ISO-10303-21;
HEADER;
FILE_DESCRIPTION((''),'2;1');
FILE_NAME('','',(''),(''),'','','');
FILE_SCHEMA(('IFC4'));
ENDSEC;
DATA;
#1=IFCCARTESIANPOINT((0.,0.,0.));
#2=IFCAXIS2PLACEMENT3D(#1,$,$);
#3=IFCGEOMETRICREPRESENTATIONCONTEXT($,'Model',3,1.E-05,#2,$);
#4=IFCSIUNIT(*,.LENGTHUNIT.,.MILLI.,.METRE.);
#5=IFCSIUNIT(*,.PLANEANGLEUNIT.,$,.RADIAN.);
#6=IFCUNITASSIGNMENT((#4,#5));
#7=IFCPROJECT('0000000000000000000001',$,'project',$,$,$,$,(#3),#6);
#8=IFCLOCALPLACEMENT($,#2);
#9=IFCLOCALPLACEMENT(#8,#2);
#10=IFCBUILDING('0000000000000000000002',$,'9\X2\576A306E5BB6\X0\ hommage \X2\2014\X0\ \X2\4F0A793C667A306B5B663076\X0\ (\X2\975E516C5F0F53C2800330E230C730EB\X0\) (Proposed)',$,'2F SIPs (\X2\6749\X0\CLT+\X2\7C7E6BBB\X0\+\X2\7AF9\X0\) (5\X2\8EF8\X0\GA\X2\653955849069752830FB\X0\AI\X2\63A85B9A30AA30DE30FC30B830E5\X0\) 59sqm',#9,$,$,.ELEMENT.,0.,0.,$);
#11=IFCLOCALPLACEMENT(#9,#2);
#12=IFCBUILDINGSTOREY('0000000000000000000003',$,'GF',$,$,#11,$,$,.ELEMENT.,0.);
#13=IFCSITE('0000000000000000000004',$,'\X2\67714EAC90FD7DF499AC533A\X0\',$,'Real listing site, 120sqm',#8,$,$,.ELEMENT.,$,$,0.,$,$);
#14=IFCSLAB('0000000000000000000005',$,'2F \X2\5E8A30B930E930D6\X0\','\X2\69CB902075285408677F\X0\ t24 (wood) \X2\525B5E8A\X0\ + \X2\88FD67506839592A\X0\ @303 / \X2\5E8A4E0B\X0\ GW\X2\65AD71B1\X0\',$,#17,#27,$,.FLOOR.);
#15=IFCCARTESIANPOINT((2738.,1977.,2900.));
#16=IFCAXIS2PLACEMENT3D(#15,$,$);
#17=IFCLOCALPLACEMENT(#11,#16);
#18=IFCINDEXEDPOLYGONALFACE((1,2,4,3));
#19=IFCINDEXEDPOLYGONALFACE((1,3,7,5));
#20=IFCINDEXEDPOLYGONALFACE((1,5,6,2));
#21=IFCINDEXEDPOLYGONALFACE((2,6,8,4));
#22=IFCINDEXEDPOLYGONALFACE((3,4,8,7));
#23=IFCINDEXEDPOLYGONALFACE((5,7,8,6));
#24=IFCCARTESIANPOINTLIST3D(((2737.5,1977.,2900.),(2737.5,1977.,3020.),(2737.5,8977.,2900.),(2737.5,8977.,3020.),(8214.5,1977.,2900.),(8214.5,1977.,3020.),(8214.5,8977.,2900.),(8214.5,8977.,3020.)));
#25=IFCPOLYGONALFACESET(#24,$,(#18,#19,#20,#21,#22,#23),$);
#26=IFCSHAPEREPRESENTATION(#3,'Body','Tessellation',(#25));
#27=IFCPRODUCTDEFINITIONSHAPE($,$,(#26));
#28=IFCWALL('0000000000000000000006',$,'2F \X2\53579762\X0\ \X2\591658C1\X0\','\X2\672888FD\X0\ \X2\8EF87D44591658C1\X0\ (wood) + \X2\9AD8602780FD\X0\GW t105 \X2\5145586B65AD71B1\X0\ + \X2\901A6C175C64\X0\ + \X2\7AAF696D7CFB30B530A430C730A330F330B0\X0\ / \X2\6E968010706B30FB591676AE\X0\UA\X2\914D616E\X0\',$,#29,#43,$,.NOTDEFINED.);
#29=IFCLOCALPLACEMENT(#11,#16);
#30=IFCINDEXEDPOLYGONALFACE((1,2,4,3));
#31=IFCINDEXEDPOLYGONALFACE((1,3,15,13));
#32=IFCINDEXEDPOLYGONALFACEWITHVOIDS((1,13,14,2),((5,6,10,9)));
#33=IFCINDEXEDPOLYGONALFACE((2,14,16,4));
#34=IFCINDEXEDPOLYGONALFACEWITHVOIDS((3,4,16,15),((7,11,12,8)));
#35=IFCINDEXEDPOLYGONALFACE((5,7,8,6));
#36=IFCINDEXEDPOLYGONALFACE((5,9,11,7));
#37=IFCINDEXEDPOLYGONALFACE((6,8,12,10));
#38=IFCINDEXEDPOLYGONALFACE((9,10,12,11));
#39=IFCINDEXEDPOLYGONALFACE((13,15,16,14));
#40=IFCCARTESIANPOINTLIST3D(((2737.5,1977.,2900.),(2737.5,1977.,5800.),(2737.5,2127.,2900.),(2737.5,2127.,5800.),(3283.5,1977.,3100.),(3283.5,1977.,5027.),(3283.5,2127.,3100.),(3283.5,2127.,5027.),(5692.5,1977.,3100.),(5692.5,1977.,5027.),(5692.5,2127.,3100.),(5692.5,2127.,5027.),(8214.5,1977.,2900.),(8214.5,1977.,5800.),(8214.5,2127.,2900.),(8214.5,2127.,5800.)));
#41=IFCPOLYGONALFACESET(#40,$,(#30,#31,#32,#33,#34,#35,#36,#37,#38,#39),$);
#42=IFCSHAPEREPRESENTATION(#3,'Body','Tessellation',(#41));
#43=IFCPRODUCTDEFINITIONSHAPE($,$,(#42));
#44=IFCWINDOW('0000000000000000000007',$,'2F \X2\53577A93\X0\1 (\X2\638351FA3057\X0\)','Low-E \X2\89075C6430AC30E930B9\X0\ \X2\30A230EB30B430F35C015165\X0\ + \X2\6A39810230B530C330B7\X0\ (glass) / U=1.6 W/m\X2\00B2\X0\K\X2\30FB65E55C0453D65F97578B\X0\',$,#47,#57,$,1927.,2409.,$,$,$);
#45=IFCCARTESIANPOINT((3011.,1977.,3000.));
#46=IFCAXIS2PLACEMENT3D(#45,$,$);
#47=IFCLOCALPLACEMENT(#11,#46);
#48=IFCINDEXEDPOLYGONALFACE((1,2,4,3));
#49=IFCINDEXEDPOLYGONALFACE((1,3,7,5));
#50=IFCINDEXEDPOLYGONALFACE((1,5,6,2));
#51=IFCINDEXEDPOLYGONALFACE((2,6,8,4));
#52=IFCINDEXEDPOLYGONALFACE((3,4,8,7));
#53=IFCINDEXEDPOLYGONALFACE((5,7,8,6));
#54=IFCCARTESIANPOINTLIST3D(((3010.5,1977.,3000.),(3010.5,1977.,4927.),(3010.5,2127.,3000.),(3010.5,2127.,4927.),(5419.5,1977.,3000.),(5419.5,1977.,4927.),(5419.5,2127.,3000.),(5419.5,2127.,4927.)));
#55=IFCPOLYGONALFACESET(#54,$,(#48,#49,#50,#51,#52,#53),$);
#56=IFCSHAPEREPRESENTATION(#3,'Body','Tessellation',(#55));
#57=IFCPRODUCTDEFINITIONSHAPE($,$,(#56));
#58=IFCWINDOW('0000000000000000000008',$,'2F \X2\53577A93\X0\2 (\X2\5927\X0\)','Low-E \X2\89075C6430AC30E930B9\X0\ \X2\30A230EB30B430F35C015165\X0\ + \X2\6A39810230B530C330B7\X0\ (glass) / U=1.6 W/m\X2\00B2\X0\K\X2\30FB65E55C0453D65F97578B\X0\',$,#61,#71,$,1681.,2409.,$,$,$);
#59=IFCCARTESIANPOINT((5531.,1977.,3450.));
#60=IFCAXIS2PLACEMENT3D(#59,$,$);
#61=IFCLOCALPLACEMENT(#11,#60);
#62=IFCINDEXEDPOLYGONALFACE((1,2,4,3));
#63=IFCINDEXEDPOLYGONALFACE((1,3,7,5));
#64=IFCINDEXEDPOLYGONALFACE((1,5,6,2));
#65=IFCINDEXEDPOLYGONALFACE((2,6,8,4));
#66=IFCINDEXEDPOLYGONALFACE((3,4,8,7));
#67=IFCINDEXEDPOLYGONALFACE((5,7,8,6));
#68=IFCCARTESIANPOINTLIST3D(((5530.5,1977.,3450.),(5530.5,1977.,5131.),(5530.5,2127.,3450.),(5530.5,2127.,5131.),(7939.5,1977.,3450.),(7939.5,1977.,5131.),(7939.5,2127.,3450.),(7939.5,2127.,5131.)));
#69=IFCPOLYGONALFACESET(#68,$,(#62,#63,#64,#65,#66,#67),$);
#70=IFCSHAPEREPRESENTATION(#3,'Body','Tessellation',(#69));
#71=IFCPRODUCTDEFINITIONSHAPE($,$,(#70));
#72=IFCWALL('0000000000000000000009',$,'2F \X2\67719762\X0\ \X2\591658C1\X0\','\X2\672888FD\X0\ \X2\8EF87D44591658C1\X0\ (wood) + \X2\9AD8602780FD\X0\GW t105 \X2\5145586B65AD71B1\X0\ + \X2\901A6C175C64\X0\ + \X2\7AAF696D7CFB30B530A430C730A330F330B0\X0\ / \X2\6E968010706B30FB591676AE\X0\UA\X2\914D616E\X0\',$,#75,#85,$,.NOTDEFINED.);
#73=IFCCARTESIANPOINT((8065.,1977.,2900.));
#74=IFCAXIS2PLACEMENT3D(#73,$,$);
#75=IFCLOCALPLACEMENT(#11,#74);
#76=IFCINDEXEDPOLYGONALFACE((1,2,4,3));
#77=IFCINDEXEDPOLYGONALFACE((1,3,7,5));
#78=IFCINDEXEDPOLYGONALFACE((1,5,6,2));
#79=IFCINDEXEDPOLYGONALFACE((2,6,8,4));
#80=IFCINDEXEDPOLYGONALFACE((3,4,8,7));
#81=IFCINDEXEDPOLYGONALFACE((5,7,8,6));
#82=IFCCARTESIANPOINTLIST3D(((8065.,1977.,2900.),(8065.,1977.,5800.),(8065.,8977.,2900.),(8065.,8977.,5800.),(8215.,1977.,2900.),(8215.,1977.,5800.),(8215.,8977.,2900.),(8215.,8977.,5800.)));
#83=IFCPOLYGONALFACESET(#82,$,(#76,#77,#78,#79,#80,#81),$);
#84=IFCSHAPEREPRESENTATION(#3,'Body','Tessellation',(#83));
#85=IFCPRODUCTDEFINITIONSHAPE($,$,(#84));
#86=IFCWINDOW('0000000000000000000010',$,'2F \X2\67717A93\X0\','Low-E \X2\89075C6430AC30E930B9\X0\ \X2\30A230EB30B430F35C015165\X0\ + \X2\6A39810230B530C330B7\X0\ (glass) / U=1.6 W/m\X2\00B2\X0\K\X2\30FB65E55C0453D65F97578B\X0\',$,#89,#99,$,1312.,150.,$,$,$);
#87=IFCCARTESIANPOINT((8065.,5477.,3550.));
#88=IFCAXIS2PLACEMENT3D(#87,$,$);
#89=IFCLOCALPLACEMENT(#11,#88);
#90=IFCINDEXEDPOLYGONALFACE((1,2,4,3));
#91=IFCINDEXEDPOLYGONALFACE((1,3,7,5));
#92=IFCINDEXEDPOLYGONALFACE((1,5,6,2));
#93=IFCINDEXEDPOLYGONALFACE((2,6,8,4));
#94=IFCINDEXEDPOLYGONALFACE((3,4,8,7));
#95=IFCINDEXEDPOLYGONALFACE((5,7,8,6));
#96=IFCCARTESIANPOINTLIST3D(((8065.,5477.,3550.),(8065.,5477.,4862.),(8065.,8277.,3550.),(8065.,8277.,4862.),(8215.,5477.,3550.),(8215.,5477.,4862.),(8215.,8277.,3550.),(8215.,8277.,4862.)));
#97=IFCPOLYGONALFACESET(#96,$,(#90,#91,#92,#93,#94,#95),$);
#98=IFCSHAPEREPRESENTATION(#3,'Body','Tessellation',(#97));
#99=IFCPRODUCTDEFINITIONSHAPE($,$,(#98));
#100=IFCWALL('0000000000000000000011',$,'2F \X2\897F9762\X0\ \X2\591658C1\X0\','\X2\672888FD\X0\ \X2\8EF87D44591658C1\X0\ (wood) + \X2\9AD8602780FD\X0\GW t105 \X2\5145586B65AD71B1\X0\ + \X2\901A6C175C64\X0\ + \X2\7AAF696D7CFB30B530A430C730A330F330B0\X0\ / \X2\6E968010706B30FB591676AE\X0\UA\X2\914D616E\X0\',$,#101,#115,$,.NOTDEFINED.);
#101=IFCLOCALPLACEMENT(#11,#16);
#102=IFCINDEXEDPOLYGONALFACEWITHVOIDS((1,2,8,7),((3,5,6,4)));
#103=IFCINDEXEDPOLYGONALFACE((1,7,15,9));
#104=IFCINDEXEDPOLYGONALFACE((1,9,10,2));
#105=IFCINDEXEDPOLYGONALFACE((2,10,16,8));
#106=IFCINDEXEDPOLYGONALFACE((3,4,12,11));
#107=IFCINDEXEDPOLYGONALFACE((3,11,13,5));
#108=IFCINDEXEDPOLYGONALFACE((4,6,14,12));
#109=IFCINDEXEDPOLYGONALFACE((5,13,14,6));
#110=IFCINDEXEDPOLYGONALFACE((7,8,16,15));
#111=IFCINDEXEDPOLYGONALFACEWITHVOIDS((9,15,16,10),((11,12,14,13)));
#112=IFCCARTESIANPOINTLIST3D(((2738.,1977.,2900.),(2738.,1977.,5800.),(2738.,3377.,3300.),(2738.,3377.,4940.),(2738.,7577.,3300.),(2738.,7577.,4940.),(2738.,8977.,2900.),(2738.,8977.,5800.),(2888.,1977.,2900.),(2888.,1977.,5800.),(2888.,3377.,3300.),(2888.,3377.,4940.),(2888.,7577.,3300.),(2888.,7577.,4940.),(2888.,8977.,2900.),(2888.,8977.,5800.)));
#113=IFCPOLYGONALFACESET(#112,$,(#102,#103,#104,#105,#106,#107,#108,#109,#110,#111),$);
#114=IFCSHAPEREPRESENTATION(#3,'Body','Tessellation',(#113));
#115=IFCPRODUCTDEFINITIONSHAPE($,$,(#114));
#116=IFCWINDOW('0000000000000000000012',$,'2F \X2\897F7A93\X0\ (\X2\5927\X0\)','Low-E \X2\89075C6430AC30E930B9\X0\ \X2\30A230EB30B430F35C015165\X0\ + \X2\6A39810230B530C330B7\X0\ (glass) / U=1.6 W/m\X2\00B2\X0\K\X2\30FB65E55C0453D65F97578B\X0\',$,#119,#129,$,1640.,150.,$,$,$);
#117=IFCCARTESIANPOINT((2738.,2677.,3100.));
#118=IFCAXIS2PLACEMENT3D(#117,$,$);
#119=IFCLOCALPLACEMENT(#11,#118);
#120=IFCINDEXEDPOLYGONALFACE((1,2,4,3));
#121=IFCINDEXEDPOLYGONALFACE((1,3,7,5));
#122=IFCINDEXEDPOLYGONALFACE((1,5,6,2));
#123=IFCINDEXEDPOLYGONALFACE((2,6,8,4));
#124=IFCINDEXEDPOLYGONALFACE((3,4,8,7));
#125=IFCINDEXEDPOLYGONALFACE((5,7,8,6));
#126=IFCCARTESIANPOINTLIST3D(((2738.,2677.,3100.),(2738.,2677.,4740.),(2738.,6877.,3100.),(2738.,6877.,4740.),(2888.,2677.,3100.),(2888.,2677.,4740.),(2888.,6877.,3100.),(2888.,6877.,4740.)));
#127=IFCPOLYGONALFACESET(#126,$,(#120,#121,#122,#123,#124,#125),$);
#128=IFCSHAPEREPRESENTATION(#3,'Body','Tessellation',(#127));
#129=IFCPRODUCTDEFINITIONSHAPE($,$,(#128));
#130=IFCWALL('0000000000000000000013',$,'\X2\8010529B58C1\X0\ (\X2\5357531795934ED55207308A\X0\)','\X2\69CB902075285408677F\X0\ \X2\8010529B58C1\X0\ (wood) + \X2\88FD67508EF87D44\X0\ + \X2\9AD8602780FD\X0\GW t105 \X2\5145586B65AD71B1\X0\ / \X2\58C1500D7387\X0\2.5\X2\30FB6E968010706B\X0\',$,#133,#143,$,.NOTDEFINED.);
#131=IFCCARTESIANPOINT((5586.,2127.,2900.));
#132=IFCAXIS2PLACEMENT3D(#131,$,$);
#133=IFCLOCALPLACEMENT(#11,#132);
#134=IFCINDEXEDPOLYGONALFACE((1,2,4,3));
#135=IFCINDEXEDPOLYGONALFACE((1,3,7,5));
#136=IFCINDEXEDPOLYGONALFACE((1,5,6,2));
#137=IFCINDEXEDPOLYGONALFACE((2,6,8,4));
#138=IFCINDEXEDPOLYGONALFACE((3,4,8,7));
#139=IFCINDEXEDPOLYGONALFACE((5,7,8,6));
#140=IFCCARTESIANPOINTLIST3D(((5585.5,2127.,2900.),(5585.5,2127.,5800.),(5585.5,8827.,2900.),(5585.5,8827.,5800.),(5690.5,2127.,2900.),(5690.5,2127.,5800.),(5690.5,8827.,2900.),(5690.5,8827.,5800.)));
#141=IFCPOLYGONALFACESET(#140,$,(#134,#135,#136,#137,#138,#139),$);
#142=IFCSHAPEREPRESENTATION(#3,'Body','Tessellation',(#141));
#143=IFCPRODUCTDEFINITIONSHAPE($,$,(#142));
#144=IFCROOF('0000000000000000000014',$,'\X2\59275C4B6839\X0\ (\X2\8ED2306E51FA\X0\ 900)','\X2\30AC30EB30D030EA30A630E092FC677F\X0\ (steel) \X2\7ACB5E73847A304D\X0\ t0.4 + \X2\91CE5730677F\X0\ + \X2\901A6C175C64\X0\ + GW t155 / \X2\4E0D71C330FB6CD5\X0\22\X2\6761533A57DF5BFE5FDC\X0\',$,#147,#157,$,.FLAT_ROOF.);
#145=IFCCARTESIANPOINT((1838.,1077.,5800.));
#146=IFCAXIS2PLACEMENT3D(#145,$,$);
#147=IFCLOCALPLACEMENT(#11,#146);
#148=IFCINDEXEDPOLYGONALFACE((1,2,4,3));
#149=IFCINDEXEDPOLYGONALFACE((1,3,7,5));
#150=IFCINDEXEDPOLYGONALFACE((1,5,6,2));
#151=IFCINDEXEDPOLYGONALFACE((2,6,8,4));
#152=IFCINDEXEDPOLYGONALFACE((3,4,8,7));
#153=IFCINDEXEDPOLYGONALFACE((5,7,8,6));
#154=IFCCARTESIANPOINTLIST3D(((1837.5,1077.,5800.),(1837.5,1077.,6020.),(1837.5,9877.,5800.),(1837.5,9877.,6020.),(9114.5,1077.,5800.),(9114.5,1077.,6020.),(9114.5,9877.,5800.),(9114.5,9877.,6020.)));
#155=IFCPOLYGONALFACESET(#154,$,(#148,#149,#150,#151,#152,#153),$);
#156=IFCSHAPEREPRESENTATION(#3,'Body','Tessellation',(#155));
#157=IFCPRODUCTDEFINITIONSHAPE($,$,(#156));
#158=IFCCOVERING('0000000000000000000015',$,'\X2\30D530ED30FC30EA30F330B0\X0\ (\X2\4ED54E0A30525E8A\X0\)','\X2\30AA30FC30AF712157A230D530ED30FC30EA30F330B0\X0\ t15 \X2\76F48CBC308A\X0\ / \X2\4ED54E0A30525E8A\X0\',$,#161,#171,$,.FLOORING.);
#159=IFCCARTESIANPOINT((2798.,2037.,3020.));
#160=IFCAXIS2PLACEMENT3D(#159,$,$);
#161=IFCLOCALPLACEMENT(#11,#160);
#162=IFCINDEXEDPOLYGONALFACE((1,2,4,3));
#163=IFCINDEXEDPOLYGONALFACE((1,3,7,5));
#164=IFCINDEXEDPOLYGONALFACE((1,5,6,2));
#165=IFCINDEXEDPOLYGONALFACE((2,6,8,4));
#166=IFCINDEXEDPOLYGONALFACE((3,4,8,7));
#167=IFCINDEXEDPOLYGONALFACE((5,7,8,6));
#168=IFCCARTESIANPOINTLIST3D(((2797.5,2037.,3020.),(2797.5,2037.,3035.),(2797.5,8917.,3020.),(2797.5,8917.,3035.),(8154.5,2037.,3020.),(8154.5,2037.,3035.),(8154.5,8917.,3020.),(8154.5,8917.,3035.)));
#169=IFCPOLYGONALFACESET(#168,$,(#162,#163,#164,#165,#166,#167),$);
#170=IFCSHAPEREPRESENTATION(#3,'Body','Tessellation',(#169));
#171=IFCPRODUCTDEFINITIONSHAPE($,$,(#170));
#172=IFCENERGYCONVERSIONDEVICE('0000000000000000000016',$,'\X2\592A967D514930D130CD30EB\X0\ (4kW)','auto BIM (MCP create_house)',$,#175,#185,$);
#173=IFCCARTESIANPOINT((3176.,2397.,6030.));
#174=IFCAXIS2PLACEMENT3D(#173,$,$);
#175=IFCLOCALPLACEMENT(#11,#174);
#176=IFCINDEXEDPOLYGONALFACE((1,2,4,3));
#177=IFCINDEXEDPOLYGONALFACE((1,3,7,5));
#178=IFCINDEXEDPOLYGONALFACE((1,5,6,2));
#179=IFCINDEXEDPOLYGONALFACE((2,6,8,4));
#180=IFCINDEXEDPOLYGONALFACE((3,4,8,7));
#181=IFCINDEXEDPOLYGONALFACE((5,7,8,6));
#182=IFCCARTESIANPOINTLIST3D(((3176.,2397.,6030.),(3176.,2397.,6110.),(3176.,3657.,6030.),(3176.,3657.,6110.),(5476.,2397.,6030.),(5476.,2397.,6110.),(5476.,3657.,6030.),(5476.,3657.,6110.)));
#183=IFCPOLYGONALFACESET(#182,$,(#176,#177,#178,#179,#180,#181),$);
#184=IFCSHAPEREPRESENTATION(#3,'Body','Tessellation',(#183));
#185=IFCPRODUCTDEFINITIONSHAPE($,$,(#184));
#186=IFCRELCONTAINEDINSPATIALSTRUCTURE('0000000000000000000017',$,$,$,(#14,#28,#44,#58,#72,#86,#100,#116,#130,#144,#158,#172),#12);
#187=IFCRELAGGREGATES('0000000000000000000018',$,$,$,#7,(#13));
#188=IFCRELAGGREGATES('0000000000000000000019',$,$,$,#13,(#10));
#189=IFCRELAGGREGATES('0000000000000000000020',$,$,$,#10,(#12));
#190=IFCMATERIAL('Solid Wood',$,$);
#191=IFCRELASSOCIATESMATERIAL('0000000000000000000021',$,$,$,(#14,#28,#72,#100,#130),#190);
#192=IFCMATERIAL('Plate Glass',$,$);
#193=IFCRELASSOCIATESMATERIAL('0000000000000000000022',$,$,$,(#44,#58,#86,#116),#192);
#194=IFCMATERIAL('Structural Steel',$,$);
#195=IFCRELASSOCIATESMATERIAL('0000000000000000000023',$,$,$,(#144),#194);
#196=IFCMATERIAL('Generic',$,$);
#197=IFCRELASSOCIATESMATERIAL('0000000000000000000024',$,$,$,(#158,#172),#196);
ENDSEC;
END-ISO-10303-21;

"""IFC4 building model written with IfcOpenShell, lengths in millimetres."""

from ifc_helpers import new_model, si_unit, frame, frame_2d, origin, place, context, project, spatial, rectangle, extrude, material, element, fill, save


model = new_model("IFC4")

# Units and contexts
model_context = context("Model", 3, precision=1e-05, world=origin())
ifc_project = project(units=[si_unit("LENGTHUNIT", "METRE", prefix="MILLI"), si_unit("PLANEANGLEUNIT", "RADIAN")], contexts=[model_context])

# Site, building, storey
site_placement = place(None, origin())
site = spatial("IfcSite", under=ifc_project, at=site_placement, Name="東京都練馬区", ObjectType="Real listing site, 120sqm", CompositionType="ELEMENT", RefElevation=0.0)
building_placement = place(site_placement, origin())
building = spatial("IfcBuilding", under=site, at=building_placement, Name="9坪の家 hommage — 伊礼智に学ぶ (非公式参考モデル) (Proposed)", ObjectType="2F SIPs (杉CLT+籾殻+竹) (5軸GA改善適用・AI推定オマージュ) 59sqm", CompositionType="ELEMENT", ElevationOfRefHeight=0.0, ElevationOfTerrain=0.0)
storey_placement = place(building_placement, origin())
storey = spatial("IfcBuildingStorey", under=building, at=storey_placement, Name="GF", CompositionType="ELEMENT", Elevation=0.0)

# Slab
ifc_material_1 = material(Name="Solid Wood")
slab_placement = place(storey_placement, frame((2738.0, 1977.0, 2900.0)))
element("IfcSlab", 1, at=slab_placement, inside=storey, material=ifc_material_1, Name="2F 床スラブ", Description="構造用合板 t24 (wood) 剛床 + 製材根太 @303 / 床下 GW断熱", PredefinedType="FLOOR", context=model_context, shape_type="SweptSolid", body=[
    extrude(rectangle(XDim=5477.0, YDim=7000.0, at=frame_2d((2738.0, 3500.0))), frame((2738.0, 1977.0, 2900.0)), (0.0, 0.0, 1.0), 120.0),
])

# Wall, openings, windows
wall_1_placement = place(storey_placement, frame((2738.0, 1977.0, 2900.0)))
wall_1 = element("IfcWall", 2, at=wall_1_placement, inside=storey, material=ifc_material_1, Name="2F 南面 外壁", Description="木製 軸組外壁 (wood) + 高性能GW t105 充填断熱 + 通気層 + 窯業系サイディング / 準耐火・外皮UA配慮", PredefinedType="NOTDEFINED", context=model_context, shape_type="SweptSolid", body=[
    extrude(rectangle(XDim=5477.0, YDim=150.0, at=frame_2d((2738.0, 75.0))), frame((2738.0, 1977.0, 2900.0)), (0.0, 0.0, 1.0), 2900.0),
])
opening_1_placement = place(storey_placement, frame((3011.0, 1977.0, 3000.0)))
opening_1 = element("IfcOpeningElement", 3, at=opening_1_placement, cuts=wall_1, PredefinedType="NOTDEFINED", context=model_context, shape_type="SweptSolid", body=[
    extrude(rectangle(XDim=2409.0, YDim=150.0, at=frame_2d((1204.0, 75.0))), frame((3011.0, 1977.0, 3000.0)), (0.0, 0.0, 1.0), 1927.0),
])
opening_2_placement = place(storey_placement, frame((5531.0, 1977.0, 3450.0)))
opening_2 = element("IfcOpeningElement", 4, at=opening_2_placement, cuts=wall_1, PredefinedType="NOTDEFINED", context=model_context, shape_type="SweptSolid", body=[
    extrude(rectangle(XDim=2409.0, YDim=150.0, at=frame_2d((1204.0, 75.0))), frame((5531.0, 1977.0, 3450.0)), (0.0, 0.0, 1.0), 1681.0),
])
ifc_material_2 = material(Name="Plate Glass")
window_1_placement = place(storey_placement, frame((3011.0, 1977.0, 3000.0)))
window_1 = element("IfcWindow", 5, at=window_1_placement, inside=storey, material=ifc_material_2, Name="2F 南窓1 (掃出し)", Description="Low-E 複層ガラス アルゴン封入 + 樹脂サッシ (glass) / U=1.6 W/m²K・日射取得型", OverallHeight=1927.0, OverallWidth=2409.0, context=model_context, shape_type="SweptSolid", body=[
    extrude(rectangle(XDim=2409.0, YDim=150.0, at=frame_2d((1204.0, 75.0))), frame((3011.0, 1977.0, 3000.0)), (0.0, 0.0, 1.0), 1927.0),
])
fill(opening_1, window_1)
window_2_placement = place(storey_placement, frame((5531.0, 1977.0, 3450.0)))
window_2 = element("IfcWindow", 6, at=window_2_placement, inside=storey, material=ifc_material_2, Name="2F 南窓2 (大)", Description="Low-E 複層ガラス アルゴン封入 + 樹脂サッシ (glass) / U=1.6 W/m²K・日射取得型", OverallHeight=1681.0, OverallWidth=2409.0, context=model_context, shape_type="SweptSolid", body=[
    extrude(rectangle(XDim=2409.0, YDim=150.0, at=frame_2d((1204.0, 75.0))), frame((5531.0, 1977.0, 3450.0)), (0.0, 0.0, 1.0), 1681.0),
])
fill(opening_2, window_2)

# Walls, openings, windows
wall_2_placement = place(storey_placement, frame((8065.0, 1977.0, 2900.0)))
wall_2 = element("IfcWall", 7, at=wall_2_placement, inside=storey, material=ifc_material_1, Name="2F 東面 外壁", Description="木製 軸組外壁 (wood) + 高性能GW t105 充填断熱 + 通気層 + 窯業系サイディング / 準耐火・外皮UA配慮", PredefinedType="NOTDEFINED", context=model_context, shape_type="SweptSolid", body=[
    extrude(rectangle(XDim=150.0, YDim=7000.0, at=frame_2d((75.0, 3500.0))), frame((8065.0, 1977.0, 2900.0)), (0.0, 0.0, 1.0), 2900.0),
])
opening_3_placement = place(storey_placement, frame((8065.0, 5477.0, 3550.0)))
opening_3 = element("IfcOpeningElement", 8, at=opening_3_placement, cuts=wall_2, PredefinedType="NOTDEFINED", context=model_context, shape_type="SweptSolid", body=[
    extrude(rectangle(XDim=150.0, YDim=2800.0, at=frame_2d((75.0, 1400.0))), frame((8065.0, 5477.0, 3550.0)), (0.0, 0.0, 1.0), 1312.0),
])
window_3_placement = place(storey_placement, frame((8065.0, 5477.0, 3550.0)))
window_3 = element("IfcWindow", 9, at=window_3_placement, inside=storey, material=ifc_material_2, Name="2F 東窓", Description="Low-E 複層ガラス アルゴン封入 + 樹脂サッシ (glass) / U=1.6 W/m²K・日射取得型", OverallHeight=1312.0, OverallWidth=150.0, context=model_context, shape_type="SweptSolid", body=[
    extrude(rectangle(XDim=150.0, YDim=2800.0, at=frame_2d((75.0, 1400.0))), frame((8065.0, 5477.0, 3550.0)), (0.0, 0.0, 1.0), 1312.0),
])
fill(opening_3, window_3)
wall_3_placement = place(storey_placement, frame((2738.0, 1977.0, 2900.0)))
wall_3 = element("IfcWall", 10, at=wall_3_placement, inside=storey, material=ifc_material_1, Name="2F 西面 外壁", Description="木製 軸組外壁 (wood) + 高性能GW t105 充填断熱 + 通気層 + 窯業系サイディング / 準耐火・外皮UA配慮", PredefinedType="NOTDEFINED", context=model_context, shape_type="SweptSolid", body=[
    extrude(rectangle(XDim=150.0, YDim=7000.0, at=frame_2d((75.0, 3500.0))), frame((2738.0, 1977.0, 2900.0)), (0.0, 0.0, 1.0), 2900.0),
])
opening_4_placement = place(storey_placement, frame((2738.0, 2677.0, 3100.0)))
opening_4 = element("IfcOpeningElement", 11, at=opening_4_placement, cuts=wall_3, PredefinedType="NOTDEFINED", context=model_context, shape_type="SweptSolid", body=[
    extrude(rectangle(XDim=150.0, YDim=4200.0, at=frame_2d((75.0, 2100.0))), frame((2738.0, 2677.0, 3100.0)), (0.0, 0.0, 1.0), 1640.0),
])
window_4_placement = place(storey_placement, frame((2738.0, 2677.0, 3100.0)))
window_4 = element("IfcWindow", 12, at=window_4_placement, inside=storey, material=ifc_material_2, Name="2F 西窓 (大)", Description="Low-E 複層ガラス アルゴン封入 + 樹脂サッシ (glass) / U=1.6 W/m²K・日射取得型", OverallHeight=1640.0, OverallWidth=150.0, context=model_context, shape_type="SweptSolid", body=[
    extrude(rectangle(XDim=150.0, YDim=4200.0, at=frame_2d((75.0, 2100.0))), frame((2738.0, 2677.0, 3100.0)), (0.0, 0.0, 1.0), 1640.0),
])
fill(opening_4, window_4)

# Wall
wall_4_placement = place(storey_placement, frame((5586.0, 2127.0, 2900.0)))
element("IfcWall", 13, at=wall_4_placement, inside=storey, material=ifc_material_1, Name="耐力壁 (南北間仕切り)", Description="構造用合板 耐力壁 (wood) + 製材軸組 + 高性能GW t105 充填断熱 / 壁倍率2.5・準耐火", PredefinedType="NOTDEFINED", context=model_context, shape_type="SweptSolid", body=[
    extrude(rectangle(XDim=105.0, YDim=6700.0, at=frame_2d((52.0, 3350.0))), frame((5586.0, 2127.0, 2900.0)), (0.0, 0.0, 1.0), 2900.0),
])

# Roof
ifc_material_3 = material(Name="Structural Steel")
roof_placement = place(storey_placement, frame((1838.0, 1077.0, 5800.0)))
element("IfcRoof", 14, at=roof_placement, inside=storey, material=ifc_material_3, Name="大屋根 (軒の出 900)", Description="ガルバリウム鋼板 (steel) 立平葺き t0.4 + 野地板 + 通気層 + GW t155 / 不燃・法22条区域対応", PredefinedType="FLAT_ROOF", context=model_context, shape_type="SweptSolid", body=[
    extrude(rectangle(XDim=7277.0, YDim=8800.0, at=frame_2d((3638.0, 4400.0))), frame((1838.0, 1077.0, 5800.0)), (0.0, 0.0, 1.0), 220.0),
])

# Covering
ifc_material_4 = material(Name="Generic")
covering_placement = place(storey_placement, frame((2798.0, 2037.0, 3020.0)))
element("IfcCovering", 15, at=covering_placement, inside=storey, material=ifc_material_4, Name="フローリング (仕上げ床)", Description="オーク無垢フローリング t15 直貼り / 仕上げ床", PredefinedType="FLOORING", context=model_context, shape_type="SweptSolid", body=[
    extrude(rectangle(XDim=5357.0, YDim=6880.0, at=frame_2d((2678.0, 3440.0))), frame((2798.0, 2037.0, 3020.0)), (0.0, 0.0, 1.0), 15.0),
])

# Energy conversion device
energy_conversion_device_placement = place(storey_placement, frame((3176.0, 2397.0, 6030.0)))
element("IfcEnergyConversionDevice", 16, at=energy_conversion_device_placement, inside=storey, material=ifc_material_4, Name="太陽光パネル (4kW)", Description="auto BIM (MCP create_house)", context=model_context, shape_type="SweptSolid", body=[
    extrude(rectangle(XDim=2300.0, YDim=1260.0, at=frame_2d((1150.0, 630.0))), frame((3176.0, 2397.0, 6030.0)), (0.0, 0.0, 1.0), 80.0),
])

save(model, "model.ifc")
